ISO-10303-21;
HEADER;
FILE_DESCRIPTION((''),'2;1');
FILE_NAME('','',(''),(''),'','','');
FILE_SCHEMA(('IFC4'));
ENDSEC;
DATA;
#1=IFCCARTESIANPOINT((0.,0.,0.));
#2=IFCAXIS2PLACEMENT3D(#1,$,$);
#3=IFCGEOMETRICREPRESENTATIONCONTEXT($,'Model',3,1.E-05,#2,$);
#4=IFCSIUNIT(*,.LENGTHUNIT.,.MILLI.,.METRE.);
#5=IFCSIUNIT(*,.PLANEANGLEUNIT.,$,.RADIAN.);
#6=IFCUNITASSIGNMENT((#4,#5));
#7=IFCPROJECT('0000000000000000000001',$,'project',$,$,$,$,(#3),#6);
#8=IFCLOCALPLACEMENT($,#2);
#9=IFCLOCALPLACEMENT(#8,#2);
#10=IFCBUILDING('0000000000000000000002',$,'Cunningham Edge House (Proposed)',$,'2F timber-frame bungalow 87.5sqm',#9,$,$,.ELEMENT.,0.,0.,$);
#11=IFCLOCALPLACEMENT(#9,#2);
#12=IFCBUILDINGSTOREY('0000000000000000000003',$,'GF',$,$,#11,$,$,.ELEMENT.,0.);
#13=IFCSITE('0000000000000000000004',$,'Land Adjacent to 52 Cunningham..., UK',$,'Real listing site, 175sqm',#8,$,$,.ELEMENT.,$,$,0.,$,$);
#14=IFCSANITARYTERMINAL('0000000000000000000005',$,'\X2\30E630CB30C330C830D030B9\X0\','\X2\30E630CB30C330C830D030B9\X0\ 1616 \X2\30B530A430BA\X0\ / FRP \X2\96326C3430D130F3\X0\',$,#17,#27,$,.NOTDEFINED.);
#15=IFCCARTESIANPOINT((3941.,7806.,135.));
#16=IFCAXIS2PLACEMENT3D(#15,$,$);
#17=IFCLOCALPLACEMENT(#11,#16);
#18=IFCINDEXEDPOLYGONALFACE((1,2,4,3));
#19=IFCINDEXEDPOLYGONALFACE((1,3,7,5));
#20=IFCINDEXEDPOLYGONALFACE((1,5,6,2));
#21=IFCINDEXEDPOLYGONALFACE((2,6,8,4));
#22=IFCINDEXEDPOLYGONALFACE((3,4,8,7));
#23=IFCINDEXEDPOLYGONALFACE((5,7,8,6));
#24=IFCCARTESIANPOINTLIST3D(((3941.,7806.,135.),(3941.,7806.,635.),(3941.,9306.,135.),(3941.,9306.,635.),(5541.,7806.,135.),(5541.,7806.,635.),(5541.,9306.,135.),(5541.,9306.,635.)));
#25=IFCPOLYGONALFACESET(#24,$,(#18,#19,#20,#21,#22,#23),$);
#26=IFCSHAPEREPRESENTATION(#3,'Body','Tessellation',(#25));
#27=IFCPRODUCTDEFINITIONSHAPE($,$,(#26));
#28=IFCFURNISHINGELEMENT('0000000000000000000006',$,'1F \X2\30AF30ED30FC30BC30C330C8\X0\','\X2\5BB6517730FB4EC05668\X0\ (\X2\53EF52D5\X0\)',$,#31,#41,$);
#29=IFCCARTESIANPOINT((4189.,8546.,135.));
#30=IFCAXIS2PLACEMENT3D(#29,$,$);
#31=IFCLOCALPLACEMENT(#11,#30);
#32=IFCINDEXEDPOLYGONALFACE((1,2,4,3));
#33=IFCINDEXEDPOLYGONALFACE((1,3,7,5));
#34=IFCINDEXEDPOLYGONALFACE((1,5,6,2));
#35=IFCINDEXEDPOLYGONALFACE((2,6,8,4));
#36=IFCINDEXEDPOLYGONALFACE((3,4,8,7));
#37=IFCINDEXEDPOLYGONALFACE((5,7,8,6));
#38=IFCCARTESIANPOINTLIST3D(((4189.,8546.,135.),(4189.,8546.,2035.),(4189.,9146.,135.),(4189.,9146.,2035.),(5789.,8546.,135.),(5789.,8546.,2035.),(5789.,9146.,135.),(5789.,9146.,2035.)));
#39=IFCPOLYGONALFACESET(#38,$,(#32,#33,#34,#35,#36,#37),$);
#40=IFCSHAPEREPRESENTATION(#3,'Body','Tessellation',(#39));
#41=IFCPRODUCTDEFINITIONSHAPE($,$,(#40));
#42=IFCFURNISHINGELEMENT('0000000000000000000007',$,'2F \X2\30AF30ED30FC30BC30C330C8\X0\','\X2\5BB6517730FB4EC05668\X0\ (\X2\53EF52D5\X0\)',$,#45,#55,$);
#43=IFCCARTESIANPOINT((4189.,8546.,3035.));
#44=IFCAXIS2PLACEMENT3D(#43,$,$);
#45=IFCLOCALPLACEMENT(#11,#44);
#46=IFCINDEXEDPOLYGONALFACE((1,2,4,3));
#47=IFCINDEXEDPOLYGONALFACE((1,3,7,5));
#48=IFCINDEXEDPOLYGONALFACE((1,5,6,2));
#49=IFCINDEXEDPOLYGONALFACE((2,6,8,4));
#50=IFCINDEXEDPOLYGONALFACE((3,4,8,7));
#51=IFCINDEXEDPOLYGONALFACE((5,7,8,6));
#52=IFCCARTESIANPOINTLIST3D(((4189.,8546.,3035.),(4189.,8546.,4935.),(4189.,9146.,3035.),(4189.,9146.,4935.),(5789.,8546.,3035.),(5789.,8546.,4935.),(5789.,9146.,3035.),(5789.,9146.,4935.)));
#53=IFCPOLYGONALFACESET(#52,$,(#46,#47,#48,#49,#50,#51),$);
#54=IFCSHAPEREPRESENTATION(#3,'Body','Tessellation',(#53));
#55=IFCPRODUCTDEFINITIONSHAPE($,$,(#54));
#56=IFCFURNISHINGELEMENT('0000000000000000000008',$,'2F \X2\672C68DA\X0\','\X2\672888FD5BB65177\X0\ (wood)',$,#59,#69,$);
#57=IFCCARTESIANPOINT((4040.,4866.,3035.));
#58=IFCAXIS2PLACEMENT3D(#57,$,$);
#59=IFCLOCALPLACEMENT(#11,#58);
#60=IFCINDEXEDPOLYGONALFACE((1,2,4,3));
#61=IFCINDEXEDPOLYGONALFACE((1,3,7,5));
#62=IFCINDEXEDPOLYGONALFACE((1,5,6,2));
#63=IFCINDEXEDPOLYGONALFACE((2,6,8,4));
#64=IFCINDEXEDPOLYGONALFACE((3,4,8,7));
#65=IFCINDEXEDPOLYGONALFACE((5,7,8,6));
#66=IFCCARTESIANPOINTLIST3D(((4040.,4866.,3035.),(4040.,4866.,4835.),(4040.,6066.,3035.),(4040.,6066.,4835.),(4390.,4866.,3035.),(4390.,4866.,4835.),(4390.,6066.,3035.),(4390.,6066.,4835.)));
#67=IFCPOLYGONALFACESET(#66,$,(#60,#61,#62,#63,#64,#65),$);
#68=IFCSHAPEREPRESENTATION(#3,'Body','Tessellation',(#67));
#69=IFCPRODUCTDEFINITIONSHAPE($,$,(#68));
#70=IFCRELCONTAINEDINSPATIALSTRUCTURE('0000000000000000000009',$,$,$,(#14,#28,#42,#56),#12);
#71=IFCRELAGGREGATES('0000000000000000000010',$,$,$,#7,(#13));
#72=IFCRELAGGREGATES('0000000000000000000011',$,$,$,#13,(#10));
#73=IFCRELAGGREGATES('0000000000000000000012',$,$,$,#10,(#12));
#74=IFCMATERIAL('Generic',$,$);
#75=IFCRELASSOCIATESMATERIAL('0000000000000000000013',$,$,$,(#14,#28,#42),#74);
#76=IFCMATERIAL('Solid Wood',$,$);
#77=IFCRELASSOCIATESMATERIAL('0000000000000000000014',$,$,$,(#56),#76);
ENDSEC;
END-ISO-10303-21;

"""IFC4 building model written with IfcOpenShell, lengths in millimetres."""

from ifc_helpers import new_model, si_unit, frame, frame_2d, origin, place, context, project, spatial, rectangle, extrude, material, element, save


model = new_model("IFC4")

# Units and contexts
model_context = context("Model", 3, precision=1e-05, world=origin())
ifc_project = project(units=[si_unit("LENGTHUNIT", "METRE", prefix="MILLI"), si_unit("PLANEANGLEUNIT", "RADIAN")], contexts=[model_context])

# Site, building, storey
site_placement = place(None, origin())
site = spatial("IfcSite", under=ifc_project, at=site_placement, Name="Land Adjacent to 52 Cunningham..., UK", ObjectType="Real listing site, 175sqm", CompositionType="ELEMENT", RefElevation=0.0)
building_placement = place(site_placement, origin())
building = spatial("IfcBuilding", under=site, at=building_placement, Name="Cunningham Edge House (Proposed)", ObjectType="2F timber-frame bungalow 87.5sqm", CompositionType="ELEMENT", ElevationOfRefHeight=0.0, ElevationOfTerrain=0.0)
storey_placement = place(building_placement, origin())
storey = spatial("IfcBuildingStorey", under=building, at=storey_placement, Name="GF", CompositionType="ELEMENT", Elevation=0.0)

# Shared definitions
ifc_material_1 = material(Name="Solid Wood")

# Shared definitions
ifc_material_2 = material(Name="Generic")

# Sanitary terminal
sanitary_terminal_placement = place(storey_placement, frame((3941.0, 7806.0, 135.0)))
element("IfcSanitaryTerminal", 1, at=sanitary_terminal_placement, inside=storey, material=ifc_material_2, Name="ユニットバス", Description="ユニットバス 1616 サイズ / FRP 防水パン", PredefinedType="NOTDEFINED", context=model_context, shape_type="SweptSolid", body=[
    extrude(rectangle(XDim=1600.0, YDim=1500.0, at=frame_2d((800.0, 750.0))), frame((3941.0, 7806.0, 135.0)), (0.0, 0.0, 1.0), 500.0),
])

# Furnishing elements
furnishing_1_placement = place(storey_placement, frame((4189.0, 8546.0, 135.0)))
element("IfcFurnishingElement", 2, at=furnishing_1_placement, inside=storey, material=ifc_material_2, Name="1F クローゼット", Description="家具・什器 (可動)", context=model_context, shape_type="SweptSolid", body=[
    extrude(rectangle(XDim=1600.0, YDim=600.0, at=frame_2d((800.0, 300.0))), frame((4189.0, 8546.0, 135.0)), (0.0, 0.0, 1.0), 1900.0),
])
furnishing_2_placement = place(storey_placement, frame((4189.0, 8546.0, 3035.0)))
element("IfcFurnishingElement", 3, at=furnishing_2_placement, inside=storey, material=ifc_material_2, Name="2F クローゼット", Description="家具・什器 (可動)", context=model_context, shape_type="SweptSolid", body=[
    extrude(rectangle(XDim=1600.0, YDim=600.0, at=frame_2d((800.0, 300.0))), frame((4189.0, 8546.0, 3035.0)), (0.0, 0.0, 1.0), 1900.0),
])
furnishing_3_placement = place(storey_placement, frame((4040.0, 4866.0, 3035.0)))
element("IfcFurnishingElement", 4, at=furnishing_3_placement, inside=storey, material=ifc_material_1, Name="2F 本棚", Description="木製家具 (wood)", context=model_context, shape_type="SweptSolid", body=[
    extrude(rectangle(XDim=350.0, YDim=1200.0, at=frame_2d((175.0, 600.0))), frame((4040.0, 4866.0, 3035.0)), (0.0, 0.0, 1.0), 1800.0),
])

save(model, "model.ifc")
